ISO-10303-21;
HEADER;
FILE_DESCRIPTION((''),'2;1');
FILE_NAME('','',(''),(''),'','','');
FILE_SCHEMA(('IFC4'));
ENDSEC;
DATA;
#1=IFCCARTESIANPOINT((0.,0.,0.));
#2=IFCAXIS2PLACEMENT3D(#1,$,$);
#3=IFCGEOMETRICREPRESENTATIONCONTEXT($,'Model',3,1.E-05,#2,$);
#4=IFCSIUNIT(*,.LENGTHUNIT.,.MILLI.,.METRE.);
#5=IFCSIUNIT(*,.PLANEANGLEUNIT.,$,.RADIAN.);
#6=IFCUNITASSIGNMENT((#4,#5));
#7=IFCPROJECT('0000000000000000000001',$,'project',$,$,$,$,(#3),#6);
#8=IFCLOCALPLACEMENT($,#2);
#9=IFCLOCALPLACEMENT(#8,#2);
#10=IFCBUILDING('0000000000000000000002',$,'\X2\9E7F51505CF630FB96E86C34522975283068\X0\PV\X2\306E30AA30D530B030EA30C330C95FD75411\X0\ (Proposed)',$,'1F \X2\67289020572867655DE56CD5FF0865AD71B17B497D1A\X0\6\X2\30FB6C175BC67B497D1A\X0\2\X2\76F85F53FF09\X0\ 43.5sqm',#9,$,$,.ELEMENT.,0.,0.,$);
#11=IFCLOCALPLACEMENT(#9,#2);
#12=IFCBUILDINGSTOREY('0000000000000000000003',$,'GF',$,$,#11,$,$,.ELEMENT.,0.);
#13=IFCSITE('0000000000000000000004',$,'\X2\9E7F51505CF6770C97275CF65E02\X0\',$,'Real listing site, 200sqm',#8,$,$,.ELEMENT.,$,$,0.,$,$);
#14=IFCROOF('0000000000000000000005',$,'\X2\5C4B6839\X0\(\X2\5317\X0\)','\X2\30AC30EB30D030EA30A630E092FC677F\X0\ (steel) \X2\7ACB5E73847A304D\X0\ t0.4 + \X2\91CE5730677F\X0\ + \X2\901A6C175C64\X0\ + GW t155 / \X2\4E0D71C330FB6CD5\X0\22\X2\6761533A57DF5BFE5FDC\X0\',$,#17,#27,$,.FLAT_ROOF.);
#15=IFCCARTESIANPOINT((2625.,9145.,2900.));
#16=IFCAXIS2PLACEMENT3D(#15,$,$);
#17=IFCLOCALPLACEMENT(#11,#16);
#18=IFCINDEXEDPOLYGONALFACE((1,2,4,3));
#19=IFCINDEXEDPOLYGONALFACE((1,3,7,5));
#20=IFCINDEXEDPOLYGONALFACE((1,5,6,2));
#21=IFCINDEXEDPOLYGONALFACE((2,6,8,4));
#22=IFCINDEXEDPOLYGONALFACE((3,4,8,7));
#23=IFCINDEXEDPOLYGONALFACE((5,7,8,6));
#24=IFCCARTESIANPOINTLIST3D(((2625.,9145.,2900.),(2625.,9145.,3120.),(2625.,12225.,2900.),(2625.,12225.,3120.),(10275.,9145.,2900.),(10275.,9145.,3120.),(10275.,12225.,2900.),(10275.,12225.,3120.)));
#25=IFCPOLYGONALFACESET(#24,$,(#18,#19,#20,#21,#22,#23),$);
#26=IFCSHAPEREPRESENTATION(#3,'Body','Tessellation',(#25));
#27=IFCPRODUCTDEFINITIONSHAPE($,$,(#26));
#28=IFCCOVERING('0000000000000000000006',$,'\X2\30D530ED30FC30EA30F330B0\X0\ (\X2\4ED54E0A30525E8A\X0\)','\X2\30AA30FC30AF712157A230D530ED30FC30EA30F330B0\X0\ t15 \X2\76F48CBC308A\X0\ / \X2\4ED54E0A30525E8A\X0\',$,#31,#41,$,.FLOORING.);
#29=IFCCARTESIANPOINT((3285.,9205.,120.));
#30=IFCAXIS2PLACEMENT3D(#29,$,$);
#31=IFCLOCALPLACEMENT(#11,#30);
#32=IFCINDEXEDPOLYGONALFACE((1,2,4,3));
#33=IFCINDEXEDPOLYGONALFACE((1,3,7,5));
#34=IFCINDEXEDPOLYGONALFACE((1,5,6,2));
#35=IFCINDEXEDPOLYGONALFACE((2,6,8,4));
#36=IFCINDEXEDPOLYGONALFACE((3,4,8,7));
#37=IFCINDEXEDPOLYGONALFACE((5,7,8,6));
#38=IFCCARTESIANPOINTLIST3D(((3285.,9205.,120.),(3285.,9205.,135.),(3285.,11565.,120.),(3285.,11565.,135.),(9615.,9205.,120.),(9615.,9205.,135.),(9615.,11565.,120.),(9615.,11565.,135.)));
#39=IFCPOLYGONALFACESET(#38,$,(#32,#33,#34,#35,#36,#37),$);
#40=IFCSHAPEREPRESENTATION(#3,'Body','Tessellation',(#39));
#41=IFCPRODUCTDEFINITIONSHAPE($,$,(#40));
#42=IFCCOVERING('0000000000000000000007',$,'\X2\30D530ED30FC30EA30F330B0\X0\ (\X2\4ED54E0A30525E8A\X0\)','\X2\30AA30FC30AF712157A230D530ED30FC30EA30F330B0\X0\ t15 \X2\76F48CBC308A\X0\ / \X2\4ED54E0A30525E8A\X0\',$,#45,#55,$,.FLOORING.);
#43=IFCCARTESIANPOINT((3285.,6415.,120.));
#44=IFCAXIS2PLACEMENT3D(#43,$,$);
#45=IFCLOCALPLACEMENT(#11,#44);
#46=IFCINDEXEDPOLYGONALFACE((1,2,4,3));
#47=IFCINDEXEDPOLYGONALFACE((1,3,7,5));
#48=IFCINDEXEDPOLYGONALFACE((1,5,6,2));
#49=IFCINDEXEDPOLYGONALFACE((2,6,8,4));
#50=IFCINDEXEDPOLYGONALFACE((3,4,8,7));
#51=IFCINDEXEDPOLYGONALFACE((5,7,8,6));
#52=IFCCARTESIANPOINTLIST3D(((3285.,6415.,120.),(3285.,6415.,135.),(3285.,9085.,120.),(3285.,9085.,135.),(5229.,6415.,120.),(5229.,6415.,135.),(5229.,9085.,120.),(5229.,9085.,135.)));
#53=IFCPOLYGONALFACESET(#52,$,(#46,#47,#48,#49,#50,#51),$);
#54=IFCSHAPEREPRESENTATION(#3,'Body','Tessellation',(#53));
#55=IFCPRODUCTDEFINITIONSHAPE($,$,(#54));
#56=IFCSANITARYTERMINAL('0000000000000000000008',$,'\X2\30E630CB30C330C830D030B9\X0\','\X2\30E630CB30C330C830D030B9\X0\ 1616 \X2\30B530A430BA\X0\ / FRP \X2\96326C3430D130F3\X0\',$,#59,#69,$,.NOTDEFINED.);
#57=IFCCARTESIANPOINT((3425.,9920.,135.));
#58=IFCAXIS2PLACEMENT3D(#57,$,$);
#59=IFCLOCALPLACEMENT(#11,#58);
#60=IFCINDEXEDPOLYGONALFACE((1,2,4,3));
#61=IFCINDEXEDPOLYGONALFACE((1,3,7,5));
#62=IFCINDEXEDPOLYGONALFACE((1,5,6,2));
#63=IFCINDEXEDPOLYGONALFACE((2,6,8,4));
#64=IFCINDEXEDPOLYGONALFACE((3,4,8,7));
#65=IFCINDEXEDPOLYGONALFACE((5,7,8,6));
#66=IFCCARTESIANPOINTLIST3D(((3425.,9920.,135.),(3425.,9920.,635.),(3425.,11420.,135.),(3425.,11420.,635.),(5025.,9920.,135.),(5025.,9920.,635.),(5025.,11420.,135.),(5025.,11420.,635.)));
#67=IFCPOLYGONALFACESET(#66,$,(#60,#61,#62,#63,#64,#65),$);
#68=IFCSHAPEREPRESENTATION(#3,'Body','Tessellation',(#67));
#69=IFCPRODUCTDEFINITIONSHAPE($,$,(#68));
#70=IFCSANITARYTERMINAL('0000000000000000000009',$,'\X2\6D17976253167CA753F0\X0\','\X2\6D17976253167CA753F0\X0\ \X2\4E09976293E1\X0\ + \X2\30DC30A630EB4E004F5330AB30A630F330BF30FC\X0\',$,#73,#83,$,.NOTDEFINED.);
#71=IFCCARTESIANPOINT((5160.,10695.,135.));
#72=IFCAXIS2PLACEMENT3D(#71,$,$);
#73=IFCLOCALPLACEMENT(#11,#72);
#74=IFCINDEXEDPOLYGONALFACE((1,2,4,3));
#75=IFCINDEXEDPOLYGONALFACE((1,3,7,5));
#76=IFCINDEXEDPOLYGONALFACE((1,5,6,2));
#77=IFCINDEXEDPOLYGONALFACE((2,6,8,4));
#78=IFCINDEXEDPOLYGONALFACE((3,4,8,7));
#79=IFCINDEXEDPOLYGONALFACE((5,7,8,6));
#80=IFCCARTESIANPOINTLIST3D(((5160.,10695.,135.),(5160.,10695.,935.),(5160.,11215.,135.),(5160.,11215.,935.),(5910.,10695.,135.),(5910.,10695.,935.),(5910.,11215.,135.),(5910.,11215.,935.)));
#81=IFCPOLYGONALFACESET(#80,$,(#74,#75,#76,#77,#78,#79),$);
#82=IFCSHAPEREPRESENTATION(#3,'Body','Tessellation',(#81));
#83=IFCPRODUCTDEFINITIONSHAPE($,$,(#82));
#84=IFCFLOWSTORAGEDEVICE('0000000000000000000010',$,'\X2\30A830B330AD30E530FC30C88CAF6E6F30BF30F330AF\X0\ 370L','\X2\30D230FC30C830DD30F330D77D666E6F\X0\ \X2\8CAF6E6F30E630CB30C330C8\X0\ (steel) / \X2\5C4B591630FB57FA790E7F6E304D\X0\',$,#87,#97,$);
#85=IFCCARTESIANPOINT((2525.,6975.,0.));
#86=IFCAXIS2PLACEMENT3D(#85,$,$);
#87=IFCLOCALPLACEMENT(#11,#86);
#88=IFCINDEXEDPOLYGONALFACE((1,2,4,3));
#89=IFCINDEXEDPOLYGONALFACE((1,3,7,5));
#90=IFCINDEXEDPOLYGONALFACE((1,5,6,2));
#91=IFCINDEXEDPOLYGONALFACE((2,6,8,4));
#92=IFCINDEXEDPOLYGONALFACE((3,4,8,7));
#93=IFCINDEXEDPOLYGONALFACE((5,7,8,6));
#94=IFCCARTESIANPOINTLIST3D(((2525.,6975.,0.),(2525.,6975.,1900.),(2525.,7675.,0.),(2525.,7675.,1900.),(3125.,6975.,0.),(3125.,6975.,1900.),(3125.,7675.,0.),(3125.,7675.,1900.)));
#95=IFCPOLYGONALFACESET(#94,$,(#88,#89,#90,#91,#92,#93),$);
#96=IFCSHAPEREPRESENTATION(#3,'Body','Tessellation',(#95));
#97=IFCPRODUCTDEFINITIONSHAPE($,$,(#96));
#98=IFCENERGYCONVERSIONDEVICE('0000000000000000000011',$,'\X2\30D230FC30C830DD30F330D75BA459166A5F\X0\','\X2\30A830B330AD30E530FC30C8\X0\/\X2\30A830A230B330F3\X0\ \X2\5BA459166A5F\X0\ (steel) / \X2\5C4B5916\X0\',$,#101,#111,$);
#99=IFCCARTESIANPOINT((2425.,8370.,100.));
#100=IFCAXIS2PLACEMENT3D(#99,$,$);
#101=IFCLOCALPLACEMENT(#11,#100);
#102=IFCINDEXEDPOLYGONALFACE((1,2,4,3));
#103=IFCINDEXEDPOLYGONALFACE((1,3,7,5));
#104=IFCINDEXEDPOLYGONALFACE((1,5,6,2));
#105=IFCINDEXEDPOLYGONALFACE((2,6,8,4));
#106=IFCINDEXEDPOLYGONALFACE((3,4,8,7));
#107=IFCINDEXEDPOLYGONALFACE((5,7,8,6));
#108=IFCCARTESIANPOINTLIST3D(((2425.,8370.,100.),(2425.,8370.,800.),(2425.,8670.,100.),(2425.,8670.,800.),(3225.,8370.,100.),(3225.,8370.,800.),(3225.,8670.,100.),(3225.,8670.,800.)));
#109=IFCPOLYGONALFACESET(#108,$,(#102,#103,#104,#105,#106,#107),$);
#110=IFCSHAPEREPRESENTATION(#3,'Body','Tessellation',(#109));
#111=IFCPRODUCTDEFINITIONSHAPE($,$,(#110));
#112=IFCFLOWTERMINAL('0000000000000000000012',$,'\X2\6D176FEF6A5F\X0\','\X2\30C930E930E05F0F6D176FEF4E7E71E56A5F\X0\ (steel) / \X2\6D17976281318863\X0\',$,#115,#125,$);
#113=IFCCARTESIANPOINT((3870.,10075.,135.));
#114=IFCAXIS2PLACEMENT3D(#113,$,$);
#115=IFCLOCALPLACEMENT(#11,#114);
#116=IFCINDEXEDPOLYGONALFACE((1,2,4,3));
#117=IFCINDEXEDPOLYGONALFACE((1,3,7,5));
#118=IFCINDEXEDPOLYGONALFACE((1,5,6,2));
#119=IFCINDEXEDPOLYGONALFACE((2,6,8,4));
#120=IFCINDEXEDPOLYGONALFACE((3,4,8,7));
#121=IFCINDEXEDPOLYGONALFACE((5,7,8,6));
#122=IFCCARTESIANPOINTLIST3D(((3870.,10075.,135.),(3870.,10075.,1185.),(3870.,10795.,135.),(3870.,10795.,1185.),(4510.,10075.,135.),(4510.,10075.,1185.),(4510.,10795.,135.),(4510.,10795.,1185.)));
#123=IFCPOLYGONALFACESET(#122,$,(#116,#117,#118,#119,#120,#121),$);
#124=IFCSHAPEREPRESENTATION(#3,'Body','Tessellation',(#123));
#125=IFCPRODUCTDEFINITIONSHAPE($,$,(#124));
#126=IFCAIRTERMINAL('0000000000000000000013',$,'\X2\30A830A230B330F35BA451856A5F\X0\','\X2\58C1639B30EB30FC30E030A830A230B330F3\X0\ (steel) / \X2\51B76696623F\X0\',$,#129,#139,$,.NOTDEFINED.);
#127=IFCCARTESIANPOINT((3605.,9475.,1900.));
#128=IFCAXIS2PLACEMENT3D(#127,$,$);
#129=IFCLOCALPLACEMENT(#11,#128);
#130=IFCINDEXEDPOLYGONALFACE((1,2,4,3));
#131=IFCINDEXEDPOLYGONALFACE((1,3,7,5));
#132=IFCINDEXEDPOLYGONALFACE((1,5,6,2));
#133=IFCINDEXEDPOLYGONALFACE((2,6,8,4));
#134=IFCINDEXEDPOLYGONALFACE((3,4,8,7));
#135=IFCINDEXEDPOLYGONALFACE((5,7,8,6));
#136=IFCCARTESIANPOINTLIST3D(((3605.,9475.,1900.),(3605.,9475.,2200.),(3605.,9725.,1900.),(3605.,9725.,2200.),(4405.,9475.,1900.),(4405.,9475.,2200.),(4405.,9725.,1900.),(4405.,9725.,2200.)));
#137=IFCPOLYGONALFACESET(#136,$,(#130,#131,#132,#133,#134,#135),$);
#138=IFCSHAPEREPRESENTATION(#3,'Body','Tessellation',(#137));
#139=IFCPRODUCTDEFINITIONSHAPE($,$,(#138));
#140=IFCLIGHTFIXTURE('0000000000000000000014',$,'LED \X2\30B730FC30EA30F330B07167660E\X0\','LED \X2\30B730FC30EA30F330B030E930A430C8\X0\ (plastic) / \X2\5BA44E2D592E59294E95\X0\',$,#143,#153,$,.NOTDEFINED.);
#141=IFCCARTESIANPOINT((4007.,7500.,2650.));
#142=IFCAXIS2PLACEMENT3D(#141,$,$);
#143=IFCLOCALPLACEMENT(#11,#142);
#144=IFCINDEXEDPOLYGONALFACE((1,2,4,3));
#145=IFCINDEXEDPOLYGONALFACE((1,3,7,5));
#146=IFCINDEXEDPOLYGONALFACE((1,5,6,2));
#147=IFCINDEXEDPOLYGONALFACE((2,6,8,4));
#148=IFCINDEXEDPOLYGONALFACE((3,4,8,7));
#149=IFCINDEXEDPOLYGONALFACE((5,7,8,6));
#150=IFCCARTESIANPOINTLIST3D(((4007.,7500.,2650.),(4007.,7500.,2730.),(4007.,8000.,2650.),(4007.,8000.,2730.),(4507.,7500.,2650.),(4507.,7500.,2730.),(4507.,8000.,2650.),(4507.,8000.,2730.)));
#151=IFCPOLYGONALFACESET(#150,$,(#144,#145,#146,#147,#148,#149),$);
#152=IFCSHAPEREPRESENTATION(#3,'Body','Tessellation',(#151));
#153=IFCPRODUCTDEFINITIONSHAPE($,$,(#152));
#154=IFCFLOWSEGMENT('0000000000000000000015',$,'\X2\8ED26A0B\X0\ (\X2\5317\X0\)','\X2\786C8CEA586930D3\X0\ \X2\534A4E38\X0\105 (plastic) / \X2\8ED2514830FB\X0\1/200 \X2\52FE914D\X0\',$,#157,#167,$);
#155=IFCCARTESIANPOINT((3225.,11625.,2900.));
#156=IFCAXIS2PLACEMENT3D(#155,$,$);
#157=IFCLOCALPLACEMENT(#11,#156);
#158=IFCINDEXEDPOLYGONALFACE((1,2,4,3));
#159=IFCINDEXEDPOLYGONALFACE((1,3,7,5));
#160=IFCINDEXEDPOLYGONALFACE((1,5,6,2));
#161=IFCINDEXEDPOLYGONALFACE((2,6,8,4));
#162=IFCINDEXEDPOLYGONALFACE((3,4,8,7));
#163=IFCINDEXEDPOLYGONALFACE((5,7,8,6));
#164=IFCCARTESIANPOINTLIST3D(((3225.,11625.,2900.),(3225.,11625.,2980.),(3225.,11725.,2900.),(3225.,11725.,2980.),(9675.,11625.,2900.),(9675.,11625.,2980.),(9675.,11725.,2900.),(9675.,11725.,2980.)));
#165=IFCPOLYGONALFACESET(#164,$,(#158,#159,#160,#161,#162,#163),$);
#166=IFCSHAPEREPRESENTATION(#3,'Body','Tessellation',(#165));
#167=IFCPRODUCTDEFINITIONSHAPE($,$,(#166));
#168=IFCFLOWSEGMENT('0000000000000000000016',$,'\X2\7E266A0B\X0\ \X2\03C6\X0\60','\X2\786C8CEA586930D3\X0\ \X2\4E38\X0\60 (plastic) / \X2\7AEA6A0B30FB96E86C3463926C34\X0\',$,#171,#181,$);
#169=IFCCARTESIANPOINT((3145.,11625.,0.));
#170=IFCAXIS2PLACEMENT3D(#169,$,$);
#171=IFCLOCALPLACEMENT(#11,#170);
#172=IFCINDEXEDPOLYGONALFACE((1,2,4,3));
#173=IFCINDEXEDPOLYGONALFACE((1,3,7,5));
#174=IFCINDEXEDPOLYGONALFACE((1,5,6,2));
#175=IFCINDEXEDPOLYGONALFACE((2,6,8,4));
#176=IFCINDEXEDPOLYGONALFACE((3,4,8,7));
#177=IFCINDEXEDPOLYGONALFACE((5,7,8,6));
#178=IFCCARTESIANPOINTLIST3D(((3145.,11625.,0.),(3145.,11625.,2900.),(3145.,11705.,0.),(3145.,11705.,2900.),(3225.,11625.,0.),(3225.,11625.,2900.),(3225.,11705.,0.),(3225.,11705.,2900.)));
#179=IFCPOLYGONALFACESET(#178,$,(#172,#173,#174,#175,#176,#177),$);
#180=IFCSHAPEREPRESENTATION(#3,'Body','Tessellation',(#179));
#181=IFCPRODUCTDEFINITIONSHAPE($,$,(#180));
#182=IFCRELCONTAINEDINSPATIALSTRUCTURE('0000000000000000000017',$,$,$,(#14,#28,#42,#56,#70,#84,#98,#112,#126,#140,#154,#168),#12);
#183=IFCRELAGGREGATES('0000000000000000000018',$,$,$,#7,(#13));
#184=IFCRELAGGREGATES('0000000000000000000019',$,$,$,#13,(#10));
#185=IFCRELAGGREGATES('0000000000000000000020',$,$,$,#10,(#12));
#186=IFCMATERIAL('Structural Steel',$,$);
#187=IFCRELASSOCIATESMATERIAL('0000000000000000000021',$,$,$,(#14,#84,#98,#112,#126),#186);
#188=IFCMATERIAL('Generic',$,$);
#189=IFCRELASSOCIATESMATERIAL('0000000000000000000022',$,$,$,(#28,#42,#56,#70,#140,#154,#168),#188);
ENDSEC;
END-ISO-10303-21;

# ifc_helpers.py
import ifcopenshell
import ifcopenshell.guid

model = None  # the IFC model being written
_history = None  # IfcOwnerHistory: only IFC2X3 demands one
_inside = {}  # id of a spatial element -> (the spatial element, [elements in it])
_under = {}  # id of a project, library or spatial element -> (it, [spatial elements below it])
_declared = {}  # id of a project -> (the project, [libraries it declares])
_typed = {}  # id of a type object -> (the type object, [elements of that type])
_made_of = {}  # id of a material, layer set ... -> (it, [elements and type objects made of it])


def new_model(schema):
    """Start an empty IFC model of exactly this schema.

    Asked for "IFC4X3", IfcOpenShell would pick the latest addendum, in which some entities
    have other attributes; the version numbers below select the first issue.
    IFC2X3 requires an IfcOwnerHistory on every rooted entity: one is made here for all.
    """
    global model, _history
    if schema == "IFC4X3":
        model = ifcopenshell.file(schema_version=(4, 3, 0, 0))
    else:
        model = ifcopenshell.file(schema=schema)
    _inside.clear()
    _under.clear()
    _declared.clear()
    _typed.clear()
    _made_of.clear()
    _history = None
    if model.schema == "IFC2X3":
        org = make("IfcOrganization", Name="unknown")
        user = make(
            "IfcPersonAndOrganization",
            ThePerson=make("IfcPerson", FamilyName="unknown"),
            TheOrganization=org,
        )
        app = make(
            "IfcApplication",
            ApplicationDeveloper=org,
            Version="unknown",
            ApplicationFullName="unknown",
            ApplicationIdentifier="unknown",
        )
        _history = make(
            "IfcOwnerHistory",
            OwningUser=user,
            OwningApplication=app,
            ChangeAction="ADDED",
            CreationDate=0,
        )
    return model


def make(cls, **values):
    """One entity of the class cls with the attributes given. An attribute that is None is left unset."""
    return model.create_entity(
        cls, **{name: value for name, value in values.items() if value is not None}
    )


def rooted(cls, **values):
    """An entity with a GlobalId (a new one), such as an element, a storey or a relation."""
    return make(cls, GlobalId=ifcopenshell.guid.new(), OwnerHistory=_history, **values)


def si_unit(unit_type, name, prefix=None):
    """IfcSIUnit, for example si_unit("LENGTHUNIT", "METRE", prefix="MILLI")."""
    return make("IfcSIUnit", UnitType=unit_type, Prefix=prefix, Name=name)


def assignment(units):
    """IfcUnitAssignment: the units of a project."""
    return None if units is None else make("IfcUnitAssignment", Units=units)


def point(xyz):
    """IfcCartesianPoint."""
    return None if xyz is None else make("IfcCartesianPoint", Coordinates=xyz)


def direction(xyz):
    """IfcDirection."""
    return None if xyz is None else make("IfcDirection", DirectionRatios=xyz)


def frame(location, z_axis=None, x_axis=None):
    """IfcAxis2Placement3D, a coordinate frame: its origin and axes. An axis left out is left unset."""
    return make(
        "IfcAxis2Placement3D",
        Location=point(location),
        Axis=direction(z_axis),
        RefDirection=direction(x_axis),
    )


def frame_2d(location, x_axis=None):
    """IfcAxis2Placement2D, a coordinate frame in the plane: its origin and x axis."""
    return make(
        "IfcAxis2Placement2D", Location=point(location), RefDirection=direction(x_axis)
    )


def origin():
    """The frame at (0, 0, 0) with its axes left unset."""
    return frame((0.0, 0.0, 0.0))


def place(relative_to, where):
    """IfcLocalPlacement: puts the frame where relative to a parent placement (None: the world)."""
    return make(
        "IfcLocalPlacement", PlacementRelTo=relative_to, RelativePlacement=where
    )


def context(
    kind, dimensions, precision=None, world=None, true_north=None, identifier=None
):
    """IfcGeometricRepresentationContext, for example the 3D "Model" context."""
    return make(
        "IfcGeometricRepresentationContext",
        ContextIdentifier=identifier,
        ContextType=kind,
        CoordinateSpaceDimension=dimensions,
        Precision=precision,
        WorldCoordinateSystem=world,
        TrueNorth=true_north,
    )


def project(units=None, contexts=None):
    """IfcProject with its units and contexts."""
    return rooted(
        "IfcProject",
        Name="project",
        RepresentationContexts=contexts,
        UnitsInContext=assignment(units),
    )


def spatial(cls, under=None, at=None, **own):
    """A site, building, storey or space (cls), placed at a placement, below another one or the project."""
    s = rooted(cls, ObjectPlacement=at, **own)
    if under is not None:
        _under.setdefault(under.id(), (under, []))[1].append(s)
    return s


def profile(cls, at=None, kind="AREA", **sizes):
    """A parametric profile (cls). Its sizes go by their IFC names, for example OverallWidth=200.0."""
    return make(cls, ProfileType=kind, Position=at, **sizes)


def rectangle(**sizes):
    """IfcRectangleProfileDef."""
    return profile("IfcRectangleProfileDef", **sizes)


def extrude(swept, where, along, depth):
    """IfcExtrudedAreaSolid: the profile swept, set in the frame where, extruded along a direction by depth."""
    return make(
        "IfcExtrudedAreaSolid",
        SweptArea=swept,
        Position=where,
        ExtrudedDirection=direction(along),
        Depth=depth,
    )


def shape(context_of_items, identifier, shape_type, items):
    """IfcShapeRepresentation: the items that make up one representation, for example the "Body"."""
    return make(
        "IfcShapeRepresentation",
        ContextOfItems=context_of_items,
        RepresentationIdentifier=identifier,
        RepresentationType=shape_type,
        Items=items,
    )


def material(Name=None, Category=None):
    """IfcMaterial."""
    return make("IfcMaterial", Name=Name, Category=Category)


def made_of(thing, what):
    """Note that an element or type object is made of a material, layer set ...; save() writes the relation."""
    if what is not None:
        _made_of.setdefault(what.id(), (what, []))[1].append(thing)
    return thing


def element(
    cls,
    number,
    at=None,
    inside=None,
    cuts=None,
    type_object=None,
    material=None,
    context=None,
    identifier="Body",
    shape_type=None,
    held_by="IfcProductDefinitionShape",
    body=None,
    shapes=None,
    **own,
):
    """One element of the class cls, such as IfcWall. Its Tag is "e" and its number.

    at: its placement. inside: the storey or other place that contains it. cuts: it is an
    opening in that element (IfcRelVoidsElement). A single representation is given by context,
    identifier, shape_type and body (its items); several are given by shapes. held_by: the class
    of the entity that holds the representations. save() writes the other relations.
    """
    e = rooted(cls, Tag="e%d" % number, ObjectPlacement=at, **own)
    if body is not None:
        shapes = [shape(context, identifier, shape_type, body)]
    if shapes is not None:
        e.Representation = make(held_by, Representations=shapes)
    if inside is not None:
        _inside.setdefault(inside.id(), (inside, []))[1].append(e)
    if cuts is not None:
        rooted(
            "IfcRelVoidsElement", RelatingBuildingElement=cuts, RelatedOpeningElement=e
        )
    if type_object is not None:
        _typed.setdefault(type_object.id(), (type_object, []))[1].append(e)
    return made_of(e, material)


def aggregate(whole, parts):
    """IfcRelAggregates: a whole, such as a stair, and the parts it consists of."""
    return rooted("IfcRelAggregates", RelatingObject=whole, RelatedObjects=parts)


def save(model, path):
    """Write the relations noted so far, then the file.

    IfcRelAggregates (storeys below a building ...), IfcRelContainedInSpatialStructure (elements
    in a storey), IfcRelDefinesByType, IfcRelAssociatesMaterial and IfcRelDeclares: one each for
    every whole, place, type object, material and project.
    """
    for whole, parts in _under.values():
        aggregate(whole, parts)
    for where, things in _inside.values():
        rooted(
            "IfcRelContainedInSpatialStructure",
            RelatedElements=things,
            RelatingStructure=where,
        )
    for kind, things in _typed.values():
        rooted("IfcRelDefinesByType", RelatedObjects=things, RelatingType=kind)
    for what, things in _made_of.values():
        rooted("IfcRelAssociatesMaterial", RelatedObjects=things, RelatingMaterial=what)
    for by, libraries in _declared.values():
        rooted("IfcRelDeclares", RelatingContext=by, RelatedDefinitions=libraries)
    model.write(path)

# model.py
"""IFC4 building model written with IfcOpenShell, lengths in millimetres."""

from ifc_helpers import new_model, si_unit, frame, frame_2d, origin, place, context, project, spatial, rectangle, extrude, material, element, save


model = new_model("IFC4")

# Units and contexts
model_context = context("Model", 3, precision=1e-05, world=origin())
ifc_project = project(units=[si_unit("LENGTHUNIT", "METRE", prefix="MILLI"), si_unit("PLANEANGLEUNIT", "RADIAN")], contexts=[model_context])

# Site, building, storey
site_placement = place(None, origin())
site = spatial("IfcSite", under=ifc_project, at=site_placement, Name="鹿児島県霧島市", ObjectType="Real listing site, 200sqm", CompositionType="ELEMENT", RefElevation=0.0)
building_placement = place(site_placement, origin())
building = spatial("IfcBuilding", under=site, at=building_placement, Name="鹿児島・雨水利用とPVのオフグリッド志向 (Proposed)", ObjectType="1F 木造在来工法（断熱等級6・気密等級2相当） 43.5sqm", CompositionType="ELEMENT", ElevationOfRefHeight=0.0, ElevationOfTerrain=0.0)
storey_placement = place(building_placement, origin())
storey = spatial("IfcBuildingStorey", under=building, at=storey_placement, Name="GF", CompositionType="ELEMENT", Elevation=0.0)

# Roof
ifc_material_1 = material(Name="Structural Steel")
roof_placement = place(storey_placement, frame((2625.0, 9145.0, 2900.0)))
element("IfcRoof", 1, at=roof_placement, inside=storey, material=ifc_material_1, Name="屋根(北)", Description="ガルバリウム鋼板 (steel) 立平葺き t0.4 + 野地板 + 通気層 + GW t155 / 不燃・法22条区域対応", PredefinedType="FLAT_ROOF", context=model_context, shape_type="SweptSolid", body=[
    extrude(rectangle(XDim=7650.0, YDim=3080.0, at=frame_2d((3825.0, 1540.0))), frame((2625.0, 9145.0, 2900.0)), (0.0, 0.0, 1.0), 220.0),
])

# Coverings
ifc_material_2 = material(Name="Generic")
covering_1_placement = place(storey_placement, frame((3285.0, 9205.0, 120.0)))
element("IfcCovering", 2, at=covering_1_placement, inside=storey, material=ifc_material_2, Name="フローリング (仕上げ床)", Description="オーク無垢フローリング t15 直貼り / 仕上げ床", PredefinedType="FLOORING", context=model_context, shape_type="SweptSolid", body=[
    extrude(rectangle(XDim=6330.0, YDim=2360.0, at=frame_2d((3165.0, 1180.0))), frame((3285.0, 9205.0, 120.0)), (0.0, 0.0, 1.0), 15.0),
])
covering_2_placement = place(storey_placement, frame((3285.0, 6415.0, 120.0)))
element("IfcCovering", 3, at=covering_2_placement, inside=storey, material=ifc_material_2, Name="フローリング (仕上げ床)", Description="オーク無垢フローリング t15 直貼り / 仕上げ床", PredefinedType="FLOORING", context=model_context, shape_type="SweptSolid", body=[
    extrude(rectangle(XDim=1944.0, YDim=2670.0, at=frame_2d((972.0, 1335.0))), frame((3285.0, 6415.0, 120.0)), (0.0, 0.0, 1.0), 15.0),
])

# Sanitary terminals
sanitary_terminal_1_placement = place(storey_placement, frame((3425.0, 9920.0, 135.0)))
element("IfcSanitaryTerminal", 4, at=sanitary_terminal_1_placement, inside=storey, material=ifc_material_2, Name="ユニットバス", Description="ユニットバス 1616 サイズ / FRP 防水パン", PredefinedType="NOTDEFINED", context=model_context, shape_type="SweptSolid", body=[
    extrude(rectangle(XDim=1600.0, YDim=1500.0, at=frame_2d((800.0, 750.0))), frame((3425.0, 9920.0, 135.0)), (0.0, 0.0, 1.0), 500.0),
])
sanitary_terminal_2_placement = place(storey_placement, frame((5160.0, 10695.0, 135.0)))
element("IfcSanitaryTerminal", 5, at=sanitary_terminal_2_placement, inside=storey, material=ifc_material_2, Name="洗面化粧台", Description="洗面化粧台 三面鏡 + ボウル一体カウンター", PredefinedType="NOTDEFINED", context=model_context, shape_type="SweptSolid", body=[
    extrude(rectangle(XDim=750.0, YDim=520.0, at=frame_2d((375.0, 260.0))), frame((5160.0, 10695.0, 135.0)), (0.0, 0.0, 1.0), 800.0),
])

# Flow storage device
flow_storage_device_placement = place(storey_placement, frame((2525.0, 6975.0, 0.0)))
element("IfcFlowStorageDevice", 6, at=flow_storage_device_placement, inside=storey, material=ifc_material_1, Name="エコキュート貯湯タンク 370L", Description="ヒートポンプ給湯 貯湯ユニット (steel) / 屋外・基礎置き", context=model_context, shape_type="SweptSolid", body=[
    extrude(rectangle(XDim=600.0, YDim=700.0, at=frame_2d((300.0, 350.0))), frame((2525.0, 6975.0, 0.0)), (0.0, 0.0, 1.0), 1900.0),
])

# Energy conversion device
energy_conversion_device_placement = place(storey_placement, frame((2425.0, 8370.0, 100.0)))
element("IfcEnergyConversionDevice", 7, at=energy_conversion_device_placement, inside=storey, material=ifc_material_1, Name="ヒートポンプ室外機", Description="エコキュート/エアコン 室外機 (steel) / 屋外", context=model_context, shape_type="SweptSolid", body=[
    extrude(rectangle(XDim=800.0, YDim=300.0, at=frame_2d((400.0, 150.0))), frame((2425.0, 8370.0, 100.0)), (0.0, 0.0, 1.0), 700.0),
])

# Flow terminal
flow_terminal_placement = place(storey_placement, frame((3870.0, 10075.0, 135.0)))
element("IfcFlowTerminal", 8, at=flow_terminal_placement, inside=storey, material=ifc_material_1, Name="洗濯機", Description="ドラム式洗濯乾燥機 (steel) / 洗面脱衣", context=model_context, shape_type="SweptSolid", body=[
    extrude(rectangle(XDim=640.0, YDim=720.0, at=frame_2d((320.0, 360.0))), frame((3870.0, 10075.0, 135.0)), (0.0, 0.0, 1.0), 1050.0),
])

# Air terminal
air_terminal_placement = place(storey_placement, frame((3605.0, 9475.0, 1900.0)))
element("IfcAirTerminal", 9, at=air_terminal_placement, inside=storey, material=ifc_material_1, Name="エアコン室内機", Description="壁掛ルームエアコン (steel) / 冷暖房", PredefinedType="NOTDEFINED", context=model_context, shape_type="SweptSolid", body=[
    extrude(rectangle(XDim=800.0, YDim=250.0, at=frame_2d((400.0, 125.0))), frame((3605.0, 9475.0, 1900.0)), (0.0, 0.0, 1.0), 300.0),
])

# Light fixture
light_fixture_placement = place(storey_placement, frame((4007.0, 7500.0, 2650.0)))
element("IfcLightFixture", 10, at=light_fixture_placement, inside=storey, material=ifc_material_2, Name="LED シーリング照明", Description="LED シーリングライト (plastic) / 室中央天井", PredefinedType="NOTDEFINED", context=model_context, shape_type="SweptSolid", body=[
    extrude(rectangle(XDim=500.0, YDim=500.0, at=frame_2d((250.0, 250.0))), frame((4007.0, 7500.0, 2650.0)), (0.0, 0.0, 1.0), 80.0),
])

# Flow segments
flow_segment_1_placement = place(storey_placement, frame((3225.0, 11625.0, 2900.0)))
element("IfcFlowSegment", 11, at=flow_segment_1_placement, inside=storey, material=ifc_material_2, Name="軒樋 (北)", Description="硬質塩ビ 半丸105 (plastic) / 軒先・1/200 勾配", context=model_context, shape_type="SweptSolid", body=[
    extrude(rectangle(XDim=6450.0, YDim=100.0, at=frame_2d((3225.0, 50.0))), frame((3225.0, 11625.0, 2900.0)), (0.0, 0.0, 1.0), 80.0),
])
flow_segment_2_placement = place(storey_placement, frame((3145.0, 11625.0, 0.0)))
element("IfcFlowSegment", 12, at=flow_segment_2_placement, inside=storey, material=ifc_material_2, Name="縦樋 φ60", Description="硬質塩ビ 丸60 (plastic) / 竪樋・雨水排水", context=model_context, shape_type="SweptSolid", body=[
    extrude(rectangle(XDim=80.0, YDim=80.0, at=frame_2d((40.0, 40.0))), frame((3145.0, 11625.0, 0.0)), (0.0, 0.0, 1.0), 2900.0),
])

save(model, "model.ifc")
